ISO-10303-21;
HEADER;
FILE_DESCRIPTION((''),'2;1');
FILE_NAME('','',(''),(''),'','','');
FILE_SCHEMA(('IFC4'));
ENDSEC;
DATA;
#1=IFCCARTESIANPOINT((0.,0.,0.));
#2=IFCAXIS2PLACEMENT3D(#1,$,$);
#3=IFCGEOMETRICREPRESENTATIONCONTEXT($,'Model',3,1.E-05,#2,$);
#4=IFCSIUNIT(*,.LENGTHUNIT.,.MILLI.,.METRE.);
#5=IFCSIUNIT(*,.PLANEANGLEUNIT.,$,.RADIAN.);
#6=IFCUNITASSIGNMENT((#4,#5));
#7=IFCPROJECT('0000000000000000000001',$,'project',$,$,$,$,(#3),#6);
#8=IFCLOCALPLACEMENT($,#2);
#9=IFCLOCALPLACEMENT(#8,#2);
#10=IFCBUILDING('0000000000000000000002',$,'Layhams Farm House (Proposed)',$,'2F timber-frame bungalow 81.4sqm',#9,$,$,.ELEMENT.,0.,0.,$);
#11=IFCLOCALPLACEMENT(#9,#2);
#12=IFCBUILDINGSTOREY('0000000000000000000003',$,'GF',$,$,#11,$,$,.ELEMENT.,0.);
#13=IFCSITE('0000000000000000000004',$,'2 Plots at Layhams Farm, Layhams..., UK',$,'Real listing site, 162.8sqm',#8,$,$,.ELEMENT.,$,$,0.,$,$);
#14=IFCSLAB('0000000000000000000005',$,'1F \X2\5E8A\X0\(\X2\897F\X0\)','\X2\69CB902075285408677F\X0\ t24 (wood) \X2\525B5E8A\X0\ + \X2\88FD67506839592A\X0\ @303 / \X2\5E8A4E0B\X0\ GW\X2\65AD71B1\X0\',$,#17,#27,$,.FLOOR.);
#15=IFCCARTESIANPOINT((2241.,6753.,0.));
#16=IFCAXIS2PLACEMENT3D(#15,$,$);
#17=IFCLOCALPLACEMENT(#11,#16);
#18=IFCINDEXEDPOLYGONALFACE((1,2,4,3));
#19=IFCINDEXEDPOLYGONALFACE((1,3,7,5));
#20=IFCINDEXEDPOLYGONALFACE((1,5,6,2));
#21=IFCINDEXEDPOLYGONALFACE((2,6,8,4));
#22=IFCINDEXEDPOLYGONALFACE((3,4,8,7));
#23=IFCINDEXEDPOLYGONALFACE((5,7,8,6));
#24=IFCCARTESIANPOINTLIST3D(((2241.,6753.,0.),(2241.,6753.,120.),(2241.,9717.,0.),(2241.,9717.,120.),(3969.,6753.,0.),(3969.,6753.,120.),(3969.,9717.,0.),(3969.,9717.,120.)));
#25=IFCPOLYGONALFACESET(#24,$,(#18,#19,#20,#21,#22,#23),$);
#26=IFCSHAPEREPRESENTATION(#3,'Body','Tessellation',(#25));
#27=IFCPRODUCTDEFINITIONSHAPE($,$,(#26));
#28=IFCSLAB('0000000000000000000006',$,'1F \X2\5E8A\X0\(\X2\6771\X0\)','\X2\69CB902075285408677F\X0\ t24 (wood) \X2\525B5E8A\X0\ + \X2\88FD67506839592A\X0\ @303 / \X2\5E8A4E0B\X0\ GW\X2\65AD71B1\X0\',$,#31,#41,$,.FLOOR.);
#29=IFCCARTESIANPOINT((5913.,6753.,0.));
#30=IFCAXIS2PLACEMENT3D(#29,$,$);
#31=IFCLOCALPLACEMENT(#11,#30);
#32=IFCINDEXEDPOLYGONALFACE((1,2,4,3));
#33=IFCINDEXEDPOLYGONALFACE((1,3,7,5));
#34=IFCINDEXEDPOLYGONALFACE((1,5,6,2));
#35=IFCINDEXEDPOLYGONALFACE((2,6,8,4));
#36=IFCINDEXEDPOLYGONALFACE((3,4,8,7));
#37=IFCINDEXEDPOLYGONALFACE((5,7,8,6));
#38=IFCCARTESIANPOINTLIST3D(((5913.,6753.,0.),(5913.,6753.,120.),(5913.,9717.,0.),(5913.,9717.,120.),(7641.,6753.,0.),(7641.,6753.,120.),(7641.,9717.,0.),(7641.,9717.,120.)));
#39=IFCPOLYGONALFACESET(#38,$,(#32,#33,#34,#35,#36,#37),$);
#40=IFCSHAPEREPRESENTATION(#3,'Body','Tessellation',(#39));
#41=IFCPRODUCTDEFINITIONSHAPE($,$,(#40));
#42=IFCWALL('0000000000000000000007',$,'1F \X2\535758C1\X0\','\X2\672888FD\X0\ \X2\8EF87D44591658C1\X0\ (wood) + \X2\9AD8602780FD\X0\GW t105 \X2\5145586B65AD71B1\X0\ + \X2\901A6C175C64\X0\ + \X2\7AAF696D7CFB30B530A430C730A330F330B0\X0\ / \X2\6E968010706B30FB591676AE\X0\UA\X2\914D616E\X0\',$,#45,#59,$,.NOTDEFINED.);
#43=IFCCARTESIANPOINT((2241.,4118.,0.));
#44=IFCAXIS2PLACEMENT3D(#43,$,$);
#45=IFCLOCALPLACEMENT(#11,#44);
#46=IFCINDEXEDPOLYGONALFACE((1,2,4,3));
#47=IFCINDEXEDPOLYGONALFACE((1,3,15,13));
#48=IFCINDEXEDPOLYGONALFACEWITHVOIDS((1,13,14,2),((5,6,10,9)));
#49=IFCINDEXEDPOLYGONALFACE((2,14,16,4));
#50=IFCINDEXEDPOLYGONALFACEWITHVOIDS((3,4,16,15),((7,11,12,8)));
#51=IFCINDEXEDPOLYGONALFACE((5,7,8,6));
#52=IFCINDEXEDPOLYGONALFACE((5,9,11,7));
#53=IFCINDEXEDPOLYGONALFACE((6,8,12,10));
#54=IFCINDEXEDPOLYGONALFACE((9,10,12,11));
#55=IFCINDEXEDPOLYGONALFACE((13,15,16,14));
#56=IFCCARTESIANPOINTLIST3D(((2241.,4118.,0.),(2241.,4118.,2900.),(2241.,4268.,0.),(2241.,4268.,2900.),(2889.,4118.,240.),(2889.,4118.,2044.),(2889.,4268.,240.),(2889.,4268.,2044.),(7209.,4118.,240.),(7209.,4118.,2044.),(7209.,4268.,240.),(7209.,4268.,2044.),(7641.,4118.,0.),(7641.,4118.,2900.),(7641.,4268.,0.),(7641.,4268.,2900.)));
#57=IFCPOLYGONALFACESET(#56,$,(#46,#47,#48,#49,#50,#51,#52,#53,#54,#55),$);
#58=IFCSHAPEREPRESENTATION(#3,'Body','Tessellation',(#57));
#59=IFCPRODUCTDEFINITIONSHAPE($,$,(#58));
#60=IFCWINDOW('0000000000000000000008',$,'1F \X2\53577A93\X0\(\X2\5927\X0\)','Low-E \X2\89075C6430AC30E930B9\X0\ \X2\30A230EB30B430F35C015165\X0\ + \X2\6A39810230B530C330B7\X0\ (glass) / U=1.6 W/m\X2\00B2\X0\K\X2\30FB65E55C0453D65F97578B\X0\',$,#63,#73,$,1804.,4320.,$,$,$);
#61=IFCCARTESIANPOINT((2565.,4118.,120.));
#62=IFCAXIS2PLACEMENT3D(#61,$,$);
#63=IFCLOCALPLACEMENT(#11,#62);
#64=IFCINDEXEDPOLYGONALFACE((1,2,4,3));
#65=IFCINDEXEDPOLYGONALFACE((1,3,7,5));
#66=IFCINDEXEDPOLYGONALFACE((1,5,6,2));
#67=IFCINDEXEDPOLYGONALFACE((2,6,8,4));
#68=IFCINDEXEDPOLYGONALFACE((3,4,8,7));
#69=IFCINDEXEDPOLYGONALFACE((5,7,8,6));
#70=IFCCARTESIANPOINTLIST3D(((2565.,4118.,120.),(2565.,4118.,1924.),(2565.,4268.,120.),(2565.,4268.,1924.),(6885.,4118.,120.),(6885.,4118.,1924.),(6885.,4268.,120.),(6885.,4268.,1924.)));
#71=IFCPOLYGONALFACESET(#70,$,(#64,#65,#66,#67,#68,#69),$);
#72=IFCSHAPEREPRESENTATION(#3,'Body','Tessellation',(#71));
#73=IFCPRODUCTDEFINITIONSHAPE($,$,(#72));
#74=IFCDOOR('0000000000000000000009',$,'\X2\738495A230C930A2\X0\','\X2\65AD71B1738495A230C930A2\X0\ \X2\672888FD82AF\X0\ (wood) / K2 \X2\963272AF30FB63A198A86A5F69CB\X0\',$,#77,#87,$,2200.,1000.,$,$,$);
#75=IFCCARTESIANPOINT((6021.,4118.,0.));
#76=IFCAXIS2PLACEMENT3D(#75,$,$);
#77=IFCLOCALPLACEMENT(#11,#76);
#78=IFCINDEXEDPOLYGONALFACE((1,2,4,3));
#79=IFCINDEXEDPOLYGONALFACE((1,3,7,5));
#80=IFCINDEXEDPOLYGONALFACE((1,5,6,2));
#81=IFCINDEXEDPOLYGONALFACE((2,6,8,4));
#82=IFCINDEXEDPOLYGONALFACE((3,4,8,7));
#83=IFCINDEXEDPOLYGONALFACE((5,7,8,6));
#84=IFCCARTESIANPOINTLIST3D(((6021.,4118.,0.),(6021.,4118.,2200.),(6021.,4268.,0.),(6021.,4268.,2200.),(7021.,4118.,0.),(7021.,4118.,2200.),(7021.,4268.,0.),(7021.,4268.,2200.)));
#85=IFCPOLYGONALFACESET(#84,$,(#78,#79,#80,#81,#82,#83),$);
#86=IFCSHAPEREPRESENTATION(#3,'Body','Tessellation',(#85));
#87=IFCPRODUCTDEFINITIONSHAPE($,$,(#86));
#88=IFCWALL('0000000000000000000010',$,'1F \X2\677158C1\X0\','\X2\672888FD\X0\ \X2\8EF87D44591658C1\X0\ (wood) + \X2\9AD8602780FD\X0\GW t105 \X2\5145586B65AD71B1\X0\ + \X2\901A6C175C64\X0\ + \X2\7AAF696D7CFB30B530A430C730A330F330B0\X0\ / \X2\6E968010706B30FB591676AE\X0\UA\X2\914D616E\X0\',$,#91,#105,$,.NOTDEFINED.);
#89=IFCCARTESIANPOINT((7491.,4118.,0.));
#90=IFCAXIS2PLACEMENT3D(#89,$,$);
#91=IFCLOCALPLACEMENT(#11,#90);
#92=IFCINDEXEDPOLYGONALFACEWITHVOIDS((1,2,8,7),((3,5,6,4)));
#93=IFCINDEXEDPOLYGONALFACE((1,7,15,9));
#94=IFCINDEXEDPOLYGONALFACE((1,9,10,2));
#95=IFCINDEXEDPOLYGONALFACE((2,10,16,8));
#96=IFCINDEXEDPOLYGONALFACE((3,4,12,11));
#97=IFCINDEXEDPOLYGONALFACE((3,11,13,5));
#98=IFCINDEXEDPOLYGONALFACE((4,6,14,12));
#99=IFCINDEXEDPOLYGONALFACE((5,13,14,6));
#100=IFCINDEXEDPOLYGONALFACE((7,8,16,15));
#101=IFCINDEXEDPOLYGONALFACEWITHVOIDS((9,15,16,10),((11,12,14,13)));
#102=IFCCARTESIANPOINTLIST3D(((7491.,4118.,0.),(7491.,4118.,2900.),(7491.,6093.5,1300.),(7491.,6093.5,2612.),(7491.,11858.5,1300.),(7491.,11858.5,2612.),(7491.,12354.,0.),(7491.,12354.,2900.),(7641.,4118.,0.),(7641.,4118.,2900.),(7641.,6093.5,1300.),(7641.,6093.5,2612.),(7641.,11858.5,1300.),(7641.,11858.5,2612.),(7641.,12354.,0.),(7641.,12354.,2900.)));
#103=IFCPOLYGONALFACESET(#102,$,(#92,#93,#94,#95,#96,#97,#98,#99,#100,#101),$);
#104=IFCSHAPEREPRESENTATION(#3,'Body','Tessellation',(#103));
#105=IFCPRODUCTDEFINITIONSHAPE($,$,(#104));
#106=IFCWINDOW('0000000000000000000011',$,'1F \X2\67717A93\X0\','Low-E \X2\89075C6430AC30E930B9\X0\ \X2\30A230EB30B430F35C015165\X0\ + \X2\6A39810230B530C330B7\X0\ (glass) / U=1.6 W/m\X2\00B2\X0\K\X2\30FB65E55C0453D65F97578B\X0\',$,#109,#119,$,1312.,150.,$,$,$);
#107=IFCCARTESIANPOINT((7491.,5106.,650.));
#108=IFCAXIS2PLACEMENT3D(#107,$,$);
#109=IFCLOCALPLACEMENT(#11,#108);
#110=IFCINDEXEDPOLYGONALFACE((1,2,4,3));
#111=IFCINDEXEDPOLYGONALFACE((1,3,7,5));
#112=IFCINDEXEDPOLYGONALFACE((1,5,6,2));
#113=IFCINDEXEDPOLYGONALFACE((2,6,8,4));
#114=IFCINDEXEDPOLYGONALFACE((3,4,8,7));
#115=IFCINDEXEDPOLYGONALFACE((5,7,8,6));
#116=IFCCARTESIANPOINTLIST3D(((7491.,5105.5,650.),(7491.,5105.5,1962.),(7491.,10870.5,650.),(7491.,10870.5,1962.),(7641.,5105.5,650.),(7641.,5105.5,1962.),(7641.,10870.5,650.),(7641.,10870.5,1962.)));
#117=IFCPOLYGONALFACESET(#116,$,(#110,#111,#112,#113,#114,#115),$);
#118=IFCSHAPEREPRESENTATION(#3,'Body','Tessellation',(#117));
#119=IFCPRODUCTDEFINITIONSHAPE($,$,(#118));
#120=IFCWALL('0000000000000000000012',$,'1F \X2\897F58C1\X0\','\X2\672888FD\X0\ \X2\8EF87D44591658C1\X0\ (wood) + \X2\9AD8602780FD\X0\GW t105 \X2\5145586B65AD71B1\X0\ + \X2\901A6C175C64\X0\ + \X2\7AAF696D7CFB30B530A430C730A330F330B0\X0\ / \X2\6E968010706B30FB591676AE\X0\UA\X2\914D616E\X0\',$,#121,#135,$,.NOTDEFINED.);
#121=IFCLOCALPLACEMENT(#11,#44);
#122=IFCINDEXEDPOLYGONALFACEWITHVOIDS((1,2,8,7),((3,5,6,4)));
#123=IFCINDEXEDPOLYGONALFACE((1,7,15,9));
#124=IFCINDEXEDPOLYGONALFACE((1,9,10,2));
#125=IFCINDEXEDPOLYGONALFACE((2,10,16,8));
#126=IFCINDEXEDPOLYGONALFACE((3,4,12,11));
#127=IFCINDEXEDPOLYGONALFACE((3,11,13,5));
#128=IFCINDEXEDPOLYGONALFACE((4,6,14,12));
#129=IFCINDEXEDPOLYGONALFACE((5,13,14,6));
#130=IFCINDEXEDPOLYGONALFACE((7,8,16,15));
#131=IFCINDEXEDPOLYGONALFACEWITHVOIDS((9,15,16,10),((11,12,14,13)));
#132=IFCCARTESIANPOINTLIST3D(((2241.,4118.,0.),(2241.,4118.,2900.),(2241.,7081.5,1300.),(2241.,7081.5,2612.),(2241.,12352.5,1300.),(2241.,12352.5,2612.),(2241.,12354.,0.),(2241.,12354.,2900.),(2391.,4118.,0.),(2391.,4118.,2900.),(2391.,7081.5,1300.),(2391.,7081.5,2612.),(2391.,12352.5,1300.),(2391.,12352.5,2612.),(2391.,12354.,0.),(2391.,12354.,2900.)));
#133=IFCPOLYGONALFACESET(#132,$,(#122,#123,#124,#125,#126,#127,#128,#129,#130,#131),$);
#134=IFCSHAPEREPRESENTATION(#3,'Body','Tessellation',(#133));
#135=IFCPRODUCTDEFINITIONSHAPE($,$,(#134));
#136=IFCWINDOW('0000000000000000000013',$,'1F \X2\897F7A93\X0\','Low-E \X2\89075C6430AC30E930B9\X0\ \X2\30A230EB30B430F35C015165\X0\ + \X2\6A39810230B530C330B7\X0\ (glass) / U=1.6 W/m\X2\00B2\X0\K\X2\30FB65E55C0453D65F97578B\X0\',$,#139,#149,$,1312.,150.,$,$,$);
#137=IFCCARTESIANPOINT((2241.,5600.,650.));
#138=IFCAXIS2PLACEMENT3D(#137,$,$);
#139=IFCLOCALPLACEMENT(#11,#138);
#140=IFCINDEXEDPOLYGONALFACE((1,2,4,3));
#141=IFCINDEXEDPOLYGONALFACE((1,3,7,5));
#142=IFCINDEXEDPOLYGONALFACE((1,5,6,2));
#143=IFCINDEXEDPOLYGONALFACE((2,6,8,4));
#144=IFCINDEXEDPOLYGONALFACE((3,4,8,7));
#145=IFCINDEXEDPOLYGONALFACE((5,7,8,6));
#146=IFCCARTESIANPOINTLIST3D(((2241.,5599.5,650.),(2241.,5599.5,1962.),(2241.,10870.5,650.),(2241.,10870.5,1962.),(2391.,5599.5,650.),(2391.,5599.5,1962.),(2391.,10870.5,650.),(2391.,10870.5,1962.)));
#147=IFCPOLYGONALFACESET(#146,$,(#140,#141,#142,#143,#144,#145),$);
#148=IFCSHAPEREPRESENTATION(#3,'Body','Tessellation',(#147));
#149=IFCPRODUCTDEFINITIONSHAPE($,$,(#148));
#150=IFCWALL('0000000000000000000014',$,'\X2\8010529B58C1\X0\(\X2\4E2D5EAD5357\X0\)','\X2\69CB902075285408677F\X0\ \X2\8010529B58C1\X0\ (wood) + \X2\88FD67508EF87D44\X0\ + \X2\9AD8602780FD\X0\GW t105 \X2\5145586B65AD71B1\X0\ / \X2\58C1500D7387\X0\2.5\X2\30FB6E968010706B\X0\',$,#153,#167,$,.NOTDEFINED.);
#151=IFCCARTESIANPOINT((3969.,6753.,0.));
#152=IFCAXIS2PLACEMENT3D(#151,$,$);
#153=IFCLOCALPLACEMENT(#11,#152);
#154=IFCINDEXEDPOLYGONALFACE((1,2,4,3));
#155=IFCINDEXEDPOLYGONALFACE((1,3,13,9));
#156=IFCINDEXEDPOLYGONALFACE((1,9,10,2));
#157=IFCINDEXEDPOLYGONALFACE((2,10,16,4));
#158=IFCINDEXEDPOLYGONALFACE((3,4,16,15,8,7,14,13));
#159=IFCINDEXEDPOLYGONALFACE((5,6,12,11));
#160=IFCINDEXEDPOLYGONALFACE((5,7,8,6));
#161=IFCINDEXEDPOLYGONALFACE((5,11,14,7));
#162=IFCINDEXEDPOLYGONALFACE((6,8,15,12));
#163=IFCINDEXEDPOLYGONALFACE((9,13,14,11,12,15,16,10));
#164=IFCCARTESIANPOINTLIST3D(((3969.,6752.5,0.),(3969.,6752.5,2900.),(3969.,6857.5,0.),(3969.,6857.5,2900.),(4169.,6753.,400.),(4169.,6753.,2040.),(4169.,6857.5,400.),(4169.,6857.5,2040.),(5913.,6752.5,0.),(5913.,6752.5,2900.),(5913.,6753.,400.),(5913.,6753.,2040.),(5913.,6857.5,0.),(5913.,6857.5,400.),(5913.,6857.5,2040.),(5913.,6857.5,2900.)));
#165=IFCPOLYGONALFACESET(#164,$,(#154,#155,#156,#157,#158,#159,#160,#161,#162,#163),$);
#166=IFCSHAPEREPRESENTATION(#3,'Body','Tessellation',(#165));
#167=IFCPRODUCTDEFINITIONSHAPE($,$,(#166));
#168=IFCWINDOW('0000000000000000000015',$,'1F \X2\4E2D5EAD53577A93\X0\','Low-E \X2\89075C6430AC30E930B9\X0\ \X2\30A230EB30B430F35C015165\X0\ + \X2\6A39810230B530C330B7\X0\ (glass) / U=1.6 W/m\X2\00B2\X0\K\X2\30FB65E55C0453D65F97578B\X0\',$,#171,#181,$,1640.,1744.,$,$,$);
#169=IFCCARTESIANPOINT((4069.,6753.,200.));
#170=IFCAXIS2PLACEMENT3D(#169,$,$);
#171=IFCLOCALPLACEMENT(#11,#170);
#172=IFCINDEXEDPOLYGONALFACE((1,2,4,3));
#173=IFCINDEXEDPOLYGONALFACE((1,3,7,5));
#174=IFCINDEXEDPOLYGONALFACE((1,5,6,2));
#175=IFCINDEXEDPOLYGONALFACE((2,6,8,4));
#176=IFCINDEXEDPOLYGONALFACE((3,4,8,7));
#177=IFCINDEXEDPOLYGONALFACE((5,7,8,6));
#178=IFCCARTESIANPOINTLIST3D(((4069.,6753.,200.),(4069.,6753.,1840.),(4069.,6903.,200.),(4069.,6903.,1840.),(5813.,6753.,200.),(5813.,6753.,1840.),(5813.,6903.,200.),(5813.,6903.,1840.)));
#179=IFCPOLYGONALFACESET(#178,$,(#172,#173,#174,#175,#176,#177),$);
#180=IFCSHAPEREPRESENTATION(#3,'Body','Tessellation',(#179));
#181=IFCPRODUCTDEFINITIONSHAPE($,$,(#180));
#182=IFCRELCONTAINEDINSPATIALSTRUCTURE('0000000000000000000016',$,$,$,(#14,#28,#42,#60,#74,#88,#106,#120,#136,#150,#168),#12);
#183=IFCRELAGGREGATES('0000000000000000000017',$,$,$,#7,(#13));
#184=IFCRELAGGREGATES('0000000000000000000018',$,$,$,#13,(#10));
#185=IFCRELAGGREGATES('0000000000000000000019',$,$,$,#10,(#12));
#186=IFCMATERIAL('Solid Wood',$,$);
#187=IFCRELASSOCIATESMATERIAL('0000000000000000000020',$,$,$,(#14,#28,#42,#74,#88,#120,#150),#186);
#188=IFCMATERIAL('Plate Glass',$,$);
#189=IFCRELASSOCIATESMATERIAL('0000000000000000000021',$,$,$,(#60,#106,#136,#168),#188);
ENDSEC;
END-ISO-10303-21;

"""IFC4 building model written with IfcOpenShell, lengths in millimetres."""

from ifc_helpers import new_model, si_unit, frame, frame_2d, origin, place, context, project, spatial, rectangle, extrude, material, element, fill, save


model = new_model("IFC4")

# Units and contexts
model_context = context("Model", 3, precision=1e-05, world=origin())
ifc_project = project(units=[si_unit("LENGTHUNIT", "METRE", prefix="MILLI"), si_unit("PLANEANGLEUNIT", "RADIAN")], contexts=[model_context])

# Site, building, storey
site_placement = place(None, origin())
site = spatial("IfcSite", under=ifc_project, at=site_placement, Name="2 Plots at Layhams Farm, Layhams..., UK", ObjectType="Real listing site, 162.8sqm", CompositionType="ELEMENT", RefElevation=0.0)
building_placement = place(site_placement, origin())
building = spatial("IfcBuilding", under=site, at=building_placement, Name="Layhams Farm House (Proposed)", ObjectType="2F timber-frame bungalow 81.4sqm", CompositionType="ELEMENT", ElevationOfRefHeight=0.0, ElevationOfTerrain=0.0)
storey_placement = place(building_placement, origin())
storey = spatial("IfcBuildingStorey", under=building, at=storey_placement, Name="GF", CompositionType="ELEMENT", Elevation=0.0)

# Slabs
ifc_material_1 = material(Name="Solid Wood")
slab_1_placement = place(storey_placement, frame((2241.0, 6753.0, 0.0)))
element("IfcSlab", 1, at=slab_1_placement, inside=storey, material=ifc_material_1, Name="1F 床(西)", Description="構造用合板 t24 (wood) 剛床 + 製材根太 @303 / 床下 GW断熱", PredefinedType="FLOOR", context=model_context, shape_type="SweptSolid", body=[
    extrude(rectangle(XDim=1728.0, YDim=2964.0, at=frame_2d((864.0, 1482.0))), frame((2241.0, 6753.0, 0.0)), (0.0, 0.0, 1.0), 120.0),
])
slab_2_placement = place(storey_placement, frame((5913.0, 6753.0, 0.0)))
element("IfcSlab", 2, at=slab_2_placement, inside=storey, material=ifc_material_1, Name="1F 床(東)", Description="構造用合板 t24 (wood) 剛床 + 製材根太 @303 / 床下 GW断熱", PredefinedType="FLOOR", context=model_context, shape_type="SweptSolid", body=[
    extrude(rectangle(XDim=1728.0, YDim=2964.0, at=frame_2d((864.0, 1482.0))), frame((5913.0, 6753.0, 0.0)), (0.0, 0.0, 1.0), 120.0),
])

# Wall, openings, window, door
wall_1_placement = place(storey_placement, frame((2241.0, 4118.0, 0.0)))
wall_1 = element("IfcWall", 3, at=wall_1_placement, inside=storey, material=ifc_material_1, Name="1F 南壁", Description="木製 軸組外壁 (wood) + 高性能GW t105 充填断熱 + 通気層 + 窯業系サイディング / 準耐火・外皮UA配慮", PredefinedType="NOTDEFINED", context=model_context, shape_type="SweptSolid", body=[
    extrude(rectangle(XDim=5400.0, YDim=150.0, at=frame_2d((2700.0, 75.0))), frame((2241.0, 4118.0, 0.0)), (0.0, 0.0, 1.0), 2900.0),
])
opening_1_placement = place(storey_placement, frame((2565.0, 4118.0, 120.0)))
opening_1 = element("IfcOpeningElement", 4, at=opening_1_placement, cuts=wall_1, PredefinedType="NOTDEFINED", context=model_context, shape_type="SweptSolid", body=[
    extrude(rectangle(XDim=4320.0, YDim=150.0, at=frame_2d((2160.0, 75.0))), frame((2565.0, 4118.0, 120.0)), (0.0, 0.0, 1.0), 1804.0),
])
opening_2_placement = place(storey_placement, frame((6021.0, 4118.0, 0.0)))
opening_2 = element("IfcOpeningElement", 5, at=opening_2_placement, cuts=wall_1, PredefinedType="NOTDEFINED", context=model_context, shape_type="SweptSolid", body=[
    extrude(rectangle(XDim=1000.0, YDim=150.0, at=frame_2d((500.0, 75.0))), frame((6021.0, 4118.0, 0.0)), (0.0, 0.0, 1.0), 2200.0),
])
ifc_material_2 = material(Name="Plate Glass")
window_1_placement = place(storey_placement, frame((2565.0, 4118.0, 120.0)))
window_1 = element("IfcWindow", 6, at=window_1_placement, inside=storey, material=ifc_material_2, Name="1F 南窓(大)", Description="Low-E 複層ガラス アルゴン封入 + 樹脂サッシ (glass) / U=1.6 W/m²K・日射取得型", OverallHeight=1804.0, OverallWidth=4320.0, context=model_context, shape_type="SweptSolid", body=[
    extrude(rectangle(XDim=4320.0, YDim=150.0, at=frame_2d((2160.0, 75.0))), frame((2565.0, 4118.0, 120.0)), (0.0, 0.0, 1.0), 1804.0),
])
fill(opening_1, window_1)
door_placement = place(storey_placement, frame((6021.0, 4118.0, 0.0)))
door = element("IfcDoor", 7, at=door_placement, inside=storey, material=ifc_material_1, Name="玄関ドア", Description="断熱玄関ドア 木製芯 (wood) / K2 防犯・採風機構", OverallHeight=2200.0, OverallWidth=1000.0, context=model_context, shape_type="SweptSolid", body=[
    extrude(rectangle(XDim=1000.0, YDim=150.0, at=frame_2d((500.0, 75.0))), frame((6021.0, 4118.0, 0.0)), (0.0, 0.0, 1.0), 2200.0),
])
fill(opening_2, door)

# Walls, openings, windows
wall_2_placement = place(storey_placement, frame((7491.0, 4118.0, 0.0)))
wall_2 = element("IfcWall", 8, at=wall_2_placement, inside=storey, material=ifc_material_1, Name="1F 東壁", Description="木製 軸組外壁 (wood) + 高性能GW t105 充填断熱 + 通気層 + 窯業系サイディング / 準耐火・外皮UA配慮", PredefinedType="NOTDEFINED", context=model_context, shape_type="SweptSolid", body=[
    extrude(rectangle(XDim=150.0, YDim=8236.0, at=frame_2d((75.0, 4118.0))), frame((7491.0, 4118.0, 0.0)), (0.0, 0.0, 1.0), 2900.0),
])
opening_3_placement = place(storey_placement, frame((7491.0, 5106.0, 650.0)))
opening_3 = element("IfcOpeningElement", 9, at=opening_3_placement, cuts=wall_2, PredefinedType="NOTDEFINED", context=model_context, shape_type="SweptSolid", body=[
    extrude(rectangle(XDim=150.0, YDim=5765.0, at=frame_2d((75.0, 2882.0))), frame((7491.0, 5106.0, 650.0)), (0.0, 0.0, 1.0), 1312.0),
])
window_2_placement = place(storey_placement, frame((7491.0, 5106.0, 650.0)))
window_2 = element("IfcWindow", 10, at=window_2_placement, inside=storey, material=ifc_material_2, Name="1F 東窓", Description="Low-E 複層ガラス アルゴン封入 + 樹脂サッシ (glass) / U=1.6 W/m²K・日射取得型", OverallHeight=1312.0, OverallWidth=150.0, context=model_context, shape_type="SweptSolid", body=[
    extrude(rectangle(XDim=150.0, YDim=5765.0, at=frame_2d((75.0, 2882.0))), frame((7491.0, 5106.0, 650.0)), (0.0, 0.0, 1.0), 1312.0),
])
fill(opening_3, window_2)
wall_3_placement = place(storey_placement, frame((2241.0, 4118.0, 0.0)))
wall_3 = element("IfcWall", 11, at=wall_3_placement, inside=storey, material=ifc_material_1, Name="1F 西壁", Description="木製 軸組外壁 (wood) + 高性能GW t105 充填断熱 + 通気層 + 窯業系サイディング / 準耐火・外皮UA配慮", PredefinedType="NOTDEFINED", context=model_context, shape_type="SweptSolid", body=[
    extrude(rectangle(XDim=150.0, YDim=8236.0, at=frame_2d((75.0, 4118.0))), frame((2241.0, 4118.0, 0.0)), (0.0, 0.0, 1.0), 2900.0),
])
opening_4_placement = place(storey_placement, frame((2241.0, 5600.0, 650.0)))
opening_4 = element("IfcOpeningElement", 12, at=opening_4_placement, cuts=wall_3, PredefinedType="NOTDEFINED", context=model_context, shape_type="SweptSolid", body=[
    extrude(rectangle(XDim=150.0, YDim=5271.0, at=frame_2d((75.0, 2635.0))), frame((2241.0, 5600.0, 650.0)), (0.0, 0.0, 1.0), 1312.0),
])
window_3_placement = place(storey_placement, frame((2241.0, 5600.0, 650.0)))
window_3 = element("IfcWindow", 13, at=window_3_placement, inside=storey, material=ifc_material_2, Name="1F 西窓", Description="Low-E 複層ガラス アルゴン封入 + 樹脂サッシ (glass) / U=1.6 W/m²K・日射取得型", OverallHeight=1312.0, OverallWidth=150.0, context=model_context, shape_type="SweptSolid", body=[
    extrude(rectangle(XDim=150.0, YDim=5271.0, at=frame_2d((75.0, 2635.0))), frame((2241.0, 5600.0, 650.0)), (0.0, 0.0, 1.0), 1312.0),
])
fill(opening_4, window_3)
wall_4_placement = place(storey_placement, frame((3969.0, 6753.0, 0.0)))
wall_4 = element("IfcWall", 14, at=wall_4_placement, inside=storey, material=ifc_material_1, Name="耐力壁(中庭南)", Description="構造用合板 耐力壁 (wood) + 製材軸組 + 高性能GW t105 充填断熱 / 壁倍率2.5・準耐火", PredefinedType="NOTDEFINED", context=model_context, shape_type="SweptSolid", body=[
    extrude(rectangle(XDim=1944.0, YDim=105.0, at=frame_2d((972.0, 52.0))), frame((3969.0, 6753.0, 0.0)), (0.0, 0.0, 1.0), 2900.0),
])
opening_5_placement = place(storey_placement, frame((4069.0, 6753.0, 200.0)))
opening_5 = element("IfcOpeningElement", 15, at=opening_5_placement, cuts=wall_4, PredefinedType="NOTDEFINED", context=model_context, shape_type="SweptSolid", body=[
    extrude(rectangle(XDim=1744.0, YDim=150.0, at=frame_2d((872.0, 75.0))), frame((4069.0, 6753.0, 200.0)), (0.0, 0.0, 1.0), 1640.0),
])
window_4_placement = place(storey_placement, frame((4069.0, 6753.0, 200.0)))
window_4 = element("IfcWindow", 16, at=window_4_placement, inside=storey, material=ifc_material_2, Name="1F 中庭南窓", Description="Low-E 複層ガラス アルゴン封入 + 樹脂サッシ (glass) / U=1.6 W/m²K・日射取得型", OverallHeight=1640.0, OverallWidth=1744.0, context=model_context, shape_type="SweptSolid", body=[
    extrude(rectangle(XDim=1744.0, YDim=150.0, at=frame_2d((872.0, 75.0))), frame((4069.0, 6753.0, 200.0)), (0.0, 0.0, 1.0), 1640.0),
])
fill(opening_5, window_4)

save(model, "model.ifc")
